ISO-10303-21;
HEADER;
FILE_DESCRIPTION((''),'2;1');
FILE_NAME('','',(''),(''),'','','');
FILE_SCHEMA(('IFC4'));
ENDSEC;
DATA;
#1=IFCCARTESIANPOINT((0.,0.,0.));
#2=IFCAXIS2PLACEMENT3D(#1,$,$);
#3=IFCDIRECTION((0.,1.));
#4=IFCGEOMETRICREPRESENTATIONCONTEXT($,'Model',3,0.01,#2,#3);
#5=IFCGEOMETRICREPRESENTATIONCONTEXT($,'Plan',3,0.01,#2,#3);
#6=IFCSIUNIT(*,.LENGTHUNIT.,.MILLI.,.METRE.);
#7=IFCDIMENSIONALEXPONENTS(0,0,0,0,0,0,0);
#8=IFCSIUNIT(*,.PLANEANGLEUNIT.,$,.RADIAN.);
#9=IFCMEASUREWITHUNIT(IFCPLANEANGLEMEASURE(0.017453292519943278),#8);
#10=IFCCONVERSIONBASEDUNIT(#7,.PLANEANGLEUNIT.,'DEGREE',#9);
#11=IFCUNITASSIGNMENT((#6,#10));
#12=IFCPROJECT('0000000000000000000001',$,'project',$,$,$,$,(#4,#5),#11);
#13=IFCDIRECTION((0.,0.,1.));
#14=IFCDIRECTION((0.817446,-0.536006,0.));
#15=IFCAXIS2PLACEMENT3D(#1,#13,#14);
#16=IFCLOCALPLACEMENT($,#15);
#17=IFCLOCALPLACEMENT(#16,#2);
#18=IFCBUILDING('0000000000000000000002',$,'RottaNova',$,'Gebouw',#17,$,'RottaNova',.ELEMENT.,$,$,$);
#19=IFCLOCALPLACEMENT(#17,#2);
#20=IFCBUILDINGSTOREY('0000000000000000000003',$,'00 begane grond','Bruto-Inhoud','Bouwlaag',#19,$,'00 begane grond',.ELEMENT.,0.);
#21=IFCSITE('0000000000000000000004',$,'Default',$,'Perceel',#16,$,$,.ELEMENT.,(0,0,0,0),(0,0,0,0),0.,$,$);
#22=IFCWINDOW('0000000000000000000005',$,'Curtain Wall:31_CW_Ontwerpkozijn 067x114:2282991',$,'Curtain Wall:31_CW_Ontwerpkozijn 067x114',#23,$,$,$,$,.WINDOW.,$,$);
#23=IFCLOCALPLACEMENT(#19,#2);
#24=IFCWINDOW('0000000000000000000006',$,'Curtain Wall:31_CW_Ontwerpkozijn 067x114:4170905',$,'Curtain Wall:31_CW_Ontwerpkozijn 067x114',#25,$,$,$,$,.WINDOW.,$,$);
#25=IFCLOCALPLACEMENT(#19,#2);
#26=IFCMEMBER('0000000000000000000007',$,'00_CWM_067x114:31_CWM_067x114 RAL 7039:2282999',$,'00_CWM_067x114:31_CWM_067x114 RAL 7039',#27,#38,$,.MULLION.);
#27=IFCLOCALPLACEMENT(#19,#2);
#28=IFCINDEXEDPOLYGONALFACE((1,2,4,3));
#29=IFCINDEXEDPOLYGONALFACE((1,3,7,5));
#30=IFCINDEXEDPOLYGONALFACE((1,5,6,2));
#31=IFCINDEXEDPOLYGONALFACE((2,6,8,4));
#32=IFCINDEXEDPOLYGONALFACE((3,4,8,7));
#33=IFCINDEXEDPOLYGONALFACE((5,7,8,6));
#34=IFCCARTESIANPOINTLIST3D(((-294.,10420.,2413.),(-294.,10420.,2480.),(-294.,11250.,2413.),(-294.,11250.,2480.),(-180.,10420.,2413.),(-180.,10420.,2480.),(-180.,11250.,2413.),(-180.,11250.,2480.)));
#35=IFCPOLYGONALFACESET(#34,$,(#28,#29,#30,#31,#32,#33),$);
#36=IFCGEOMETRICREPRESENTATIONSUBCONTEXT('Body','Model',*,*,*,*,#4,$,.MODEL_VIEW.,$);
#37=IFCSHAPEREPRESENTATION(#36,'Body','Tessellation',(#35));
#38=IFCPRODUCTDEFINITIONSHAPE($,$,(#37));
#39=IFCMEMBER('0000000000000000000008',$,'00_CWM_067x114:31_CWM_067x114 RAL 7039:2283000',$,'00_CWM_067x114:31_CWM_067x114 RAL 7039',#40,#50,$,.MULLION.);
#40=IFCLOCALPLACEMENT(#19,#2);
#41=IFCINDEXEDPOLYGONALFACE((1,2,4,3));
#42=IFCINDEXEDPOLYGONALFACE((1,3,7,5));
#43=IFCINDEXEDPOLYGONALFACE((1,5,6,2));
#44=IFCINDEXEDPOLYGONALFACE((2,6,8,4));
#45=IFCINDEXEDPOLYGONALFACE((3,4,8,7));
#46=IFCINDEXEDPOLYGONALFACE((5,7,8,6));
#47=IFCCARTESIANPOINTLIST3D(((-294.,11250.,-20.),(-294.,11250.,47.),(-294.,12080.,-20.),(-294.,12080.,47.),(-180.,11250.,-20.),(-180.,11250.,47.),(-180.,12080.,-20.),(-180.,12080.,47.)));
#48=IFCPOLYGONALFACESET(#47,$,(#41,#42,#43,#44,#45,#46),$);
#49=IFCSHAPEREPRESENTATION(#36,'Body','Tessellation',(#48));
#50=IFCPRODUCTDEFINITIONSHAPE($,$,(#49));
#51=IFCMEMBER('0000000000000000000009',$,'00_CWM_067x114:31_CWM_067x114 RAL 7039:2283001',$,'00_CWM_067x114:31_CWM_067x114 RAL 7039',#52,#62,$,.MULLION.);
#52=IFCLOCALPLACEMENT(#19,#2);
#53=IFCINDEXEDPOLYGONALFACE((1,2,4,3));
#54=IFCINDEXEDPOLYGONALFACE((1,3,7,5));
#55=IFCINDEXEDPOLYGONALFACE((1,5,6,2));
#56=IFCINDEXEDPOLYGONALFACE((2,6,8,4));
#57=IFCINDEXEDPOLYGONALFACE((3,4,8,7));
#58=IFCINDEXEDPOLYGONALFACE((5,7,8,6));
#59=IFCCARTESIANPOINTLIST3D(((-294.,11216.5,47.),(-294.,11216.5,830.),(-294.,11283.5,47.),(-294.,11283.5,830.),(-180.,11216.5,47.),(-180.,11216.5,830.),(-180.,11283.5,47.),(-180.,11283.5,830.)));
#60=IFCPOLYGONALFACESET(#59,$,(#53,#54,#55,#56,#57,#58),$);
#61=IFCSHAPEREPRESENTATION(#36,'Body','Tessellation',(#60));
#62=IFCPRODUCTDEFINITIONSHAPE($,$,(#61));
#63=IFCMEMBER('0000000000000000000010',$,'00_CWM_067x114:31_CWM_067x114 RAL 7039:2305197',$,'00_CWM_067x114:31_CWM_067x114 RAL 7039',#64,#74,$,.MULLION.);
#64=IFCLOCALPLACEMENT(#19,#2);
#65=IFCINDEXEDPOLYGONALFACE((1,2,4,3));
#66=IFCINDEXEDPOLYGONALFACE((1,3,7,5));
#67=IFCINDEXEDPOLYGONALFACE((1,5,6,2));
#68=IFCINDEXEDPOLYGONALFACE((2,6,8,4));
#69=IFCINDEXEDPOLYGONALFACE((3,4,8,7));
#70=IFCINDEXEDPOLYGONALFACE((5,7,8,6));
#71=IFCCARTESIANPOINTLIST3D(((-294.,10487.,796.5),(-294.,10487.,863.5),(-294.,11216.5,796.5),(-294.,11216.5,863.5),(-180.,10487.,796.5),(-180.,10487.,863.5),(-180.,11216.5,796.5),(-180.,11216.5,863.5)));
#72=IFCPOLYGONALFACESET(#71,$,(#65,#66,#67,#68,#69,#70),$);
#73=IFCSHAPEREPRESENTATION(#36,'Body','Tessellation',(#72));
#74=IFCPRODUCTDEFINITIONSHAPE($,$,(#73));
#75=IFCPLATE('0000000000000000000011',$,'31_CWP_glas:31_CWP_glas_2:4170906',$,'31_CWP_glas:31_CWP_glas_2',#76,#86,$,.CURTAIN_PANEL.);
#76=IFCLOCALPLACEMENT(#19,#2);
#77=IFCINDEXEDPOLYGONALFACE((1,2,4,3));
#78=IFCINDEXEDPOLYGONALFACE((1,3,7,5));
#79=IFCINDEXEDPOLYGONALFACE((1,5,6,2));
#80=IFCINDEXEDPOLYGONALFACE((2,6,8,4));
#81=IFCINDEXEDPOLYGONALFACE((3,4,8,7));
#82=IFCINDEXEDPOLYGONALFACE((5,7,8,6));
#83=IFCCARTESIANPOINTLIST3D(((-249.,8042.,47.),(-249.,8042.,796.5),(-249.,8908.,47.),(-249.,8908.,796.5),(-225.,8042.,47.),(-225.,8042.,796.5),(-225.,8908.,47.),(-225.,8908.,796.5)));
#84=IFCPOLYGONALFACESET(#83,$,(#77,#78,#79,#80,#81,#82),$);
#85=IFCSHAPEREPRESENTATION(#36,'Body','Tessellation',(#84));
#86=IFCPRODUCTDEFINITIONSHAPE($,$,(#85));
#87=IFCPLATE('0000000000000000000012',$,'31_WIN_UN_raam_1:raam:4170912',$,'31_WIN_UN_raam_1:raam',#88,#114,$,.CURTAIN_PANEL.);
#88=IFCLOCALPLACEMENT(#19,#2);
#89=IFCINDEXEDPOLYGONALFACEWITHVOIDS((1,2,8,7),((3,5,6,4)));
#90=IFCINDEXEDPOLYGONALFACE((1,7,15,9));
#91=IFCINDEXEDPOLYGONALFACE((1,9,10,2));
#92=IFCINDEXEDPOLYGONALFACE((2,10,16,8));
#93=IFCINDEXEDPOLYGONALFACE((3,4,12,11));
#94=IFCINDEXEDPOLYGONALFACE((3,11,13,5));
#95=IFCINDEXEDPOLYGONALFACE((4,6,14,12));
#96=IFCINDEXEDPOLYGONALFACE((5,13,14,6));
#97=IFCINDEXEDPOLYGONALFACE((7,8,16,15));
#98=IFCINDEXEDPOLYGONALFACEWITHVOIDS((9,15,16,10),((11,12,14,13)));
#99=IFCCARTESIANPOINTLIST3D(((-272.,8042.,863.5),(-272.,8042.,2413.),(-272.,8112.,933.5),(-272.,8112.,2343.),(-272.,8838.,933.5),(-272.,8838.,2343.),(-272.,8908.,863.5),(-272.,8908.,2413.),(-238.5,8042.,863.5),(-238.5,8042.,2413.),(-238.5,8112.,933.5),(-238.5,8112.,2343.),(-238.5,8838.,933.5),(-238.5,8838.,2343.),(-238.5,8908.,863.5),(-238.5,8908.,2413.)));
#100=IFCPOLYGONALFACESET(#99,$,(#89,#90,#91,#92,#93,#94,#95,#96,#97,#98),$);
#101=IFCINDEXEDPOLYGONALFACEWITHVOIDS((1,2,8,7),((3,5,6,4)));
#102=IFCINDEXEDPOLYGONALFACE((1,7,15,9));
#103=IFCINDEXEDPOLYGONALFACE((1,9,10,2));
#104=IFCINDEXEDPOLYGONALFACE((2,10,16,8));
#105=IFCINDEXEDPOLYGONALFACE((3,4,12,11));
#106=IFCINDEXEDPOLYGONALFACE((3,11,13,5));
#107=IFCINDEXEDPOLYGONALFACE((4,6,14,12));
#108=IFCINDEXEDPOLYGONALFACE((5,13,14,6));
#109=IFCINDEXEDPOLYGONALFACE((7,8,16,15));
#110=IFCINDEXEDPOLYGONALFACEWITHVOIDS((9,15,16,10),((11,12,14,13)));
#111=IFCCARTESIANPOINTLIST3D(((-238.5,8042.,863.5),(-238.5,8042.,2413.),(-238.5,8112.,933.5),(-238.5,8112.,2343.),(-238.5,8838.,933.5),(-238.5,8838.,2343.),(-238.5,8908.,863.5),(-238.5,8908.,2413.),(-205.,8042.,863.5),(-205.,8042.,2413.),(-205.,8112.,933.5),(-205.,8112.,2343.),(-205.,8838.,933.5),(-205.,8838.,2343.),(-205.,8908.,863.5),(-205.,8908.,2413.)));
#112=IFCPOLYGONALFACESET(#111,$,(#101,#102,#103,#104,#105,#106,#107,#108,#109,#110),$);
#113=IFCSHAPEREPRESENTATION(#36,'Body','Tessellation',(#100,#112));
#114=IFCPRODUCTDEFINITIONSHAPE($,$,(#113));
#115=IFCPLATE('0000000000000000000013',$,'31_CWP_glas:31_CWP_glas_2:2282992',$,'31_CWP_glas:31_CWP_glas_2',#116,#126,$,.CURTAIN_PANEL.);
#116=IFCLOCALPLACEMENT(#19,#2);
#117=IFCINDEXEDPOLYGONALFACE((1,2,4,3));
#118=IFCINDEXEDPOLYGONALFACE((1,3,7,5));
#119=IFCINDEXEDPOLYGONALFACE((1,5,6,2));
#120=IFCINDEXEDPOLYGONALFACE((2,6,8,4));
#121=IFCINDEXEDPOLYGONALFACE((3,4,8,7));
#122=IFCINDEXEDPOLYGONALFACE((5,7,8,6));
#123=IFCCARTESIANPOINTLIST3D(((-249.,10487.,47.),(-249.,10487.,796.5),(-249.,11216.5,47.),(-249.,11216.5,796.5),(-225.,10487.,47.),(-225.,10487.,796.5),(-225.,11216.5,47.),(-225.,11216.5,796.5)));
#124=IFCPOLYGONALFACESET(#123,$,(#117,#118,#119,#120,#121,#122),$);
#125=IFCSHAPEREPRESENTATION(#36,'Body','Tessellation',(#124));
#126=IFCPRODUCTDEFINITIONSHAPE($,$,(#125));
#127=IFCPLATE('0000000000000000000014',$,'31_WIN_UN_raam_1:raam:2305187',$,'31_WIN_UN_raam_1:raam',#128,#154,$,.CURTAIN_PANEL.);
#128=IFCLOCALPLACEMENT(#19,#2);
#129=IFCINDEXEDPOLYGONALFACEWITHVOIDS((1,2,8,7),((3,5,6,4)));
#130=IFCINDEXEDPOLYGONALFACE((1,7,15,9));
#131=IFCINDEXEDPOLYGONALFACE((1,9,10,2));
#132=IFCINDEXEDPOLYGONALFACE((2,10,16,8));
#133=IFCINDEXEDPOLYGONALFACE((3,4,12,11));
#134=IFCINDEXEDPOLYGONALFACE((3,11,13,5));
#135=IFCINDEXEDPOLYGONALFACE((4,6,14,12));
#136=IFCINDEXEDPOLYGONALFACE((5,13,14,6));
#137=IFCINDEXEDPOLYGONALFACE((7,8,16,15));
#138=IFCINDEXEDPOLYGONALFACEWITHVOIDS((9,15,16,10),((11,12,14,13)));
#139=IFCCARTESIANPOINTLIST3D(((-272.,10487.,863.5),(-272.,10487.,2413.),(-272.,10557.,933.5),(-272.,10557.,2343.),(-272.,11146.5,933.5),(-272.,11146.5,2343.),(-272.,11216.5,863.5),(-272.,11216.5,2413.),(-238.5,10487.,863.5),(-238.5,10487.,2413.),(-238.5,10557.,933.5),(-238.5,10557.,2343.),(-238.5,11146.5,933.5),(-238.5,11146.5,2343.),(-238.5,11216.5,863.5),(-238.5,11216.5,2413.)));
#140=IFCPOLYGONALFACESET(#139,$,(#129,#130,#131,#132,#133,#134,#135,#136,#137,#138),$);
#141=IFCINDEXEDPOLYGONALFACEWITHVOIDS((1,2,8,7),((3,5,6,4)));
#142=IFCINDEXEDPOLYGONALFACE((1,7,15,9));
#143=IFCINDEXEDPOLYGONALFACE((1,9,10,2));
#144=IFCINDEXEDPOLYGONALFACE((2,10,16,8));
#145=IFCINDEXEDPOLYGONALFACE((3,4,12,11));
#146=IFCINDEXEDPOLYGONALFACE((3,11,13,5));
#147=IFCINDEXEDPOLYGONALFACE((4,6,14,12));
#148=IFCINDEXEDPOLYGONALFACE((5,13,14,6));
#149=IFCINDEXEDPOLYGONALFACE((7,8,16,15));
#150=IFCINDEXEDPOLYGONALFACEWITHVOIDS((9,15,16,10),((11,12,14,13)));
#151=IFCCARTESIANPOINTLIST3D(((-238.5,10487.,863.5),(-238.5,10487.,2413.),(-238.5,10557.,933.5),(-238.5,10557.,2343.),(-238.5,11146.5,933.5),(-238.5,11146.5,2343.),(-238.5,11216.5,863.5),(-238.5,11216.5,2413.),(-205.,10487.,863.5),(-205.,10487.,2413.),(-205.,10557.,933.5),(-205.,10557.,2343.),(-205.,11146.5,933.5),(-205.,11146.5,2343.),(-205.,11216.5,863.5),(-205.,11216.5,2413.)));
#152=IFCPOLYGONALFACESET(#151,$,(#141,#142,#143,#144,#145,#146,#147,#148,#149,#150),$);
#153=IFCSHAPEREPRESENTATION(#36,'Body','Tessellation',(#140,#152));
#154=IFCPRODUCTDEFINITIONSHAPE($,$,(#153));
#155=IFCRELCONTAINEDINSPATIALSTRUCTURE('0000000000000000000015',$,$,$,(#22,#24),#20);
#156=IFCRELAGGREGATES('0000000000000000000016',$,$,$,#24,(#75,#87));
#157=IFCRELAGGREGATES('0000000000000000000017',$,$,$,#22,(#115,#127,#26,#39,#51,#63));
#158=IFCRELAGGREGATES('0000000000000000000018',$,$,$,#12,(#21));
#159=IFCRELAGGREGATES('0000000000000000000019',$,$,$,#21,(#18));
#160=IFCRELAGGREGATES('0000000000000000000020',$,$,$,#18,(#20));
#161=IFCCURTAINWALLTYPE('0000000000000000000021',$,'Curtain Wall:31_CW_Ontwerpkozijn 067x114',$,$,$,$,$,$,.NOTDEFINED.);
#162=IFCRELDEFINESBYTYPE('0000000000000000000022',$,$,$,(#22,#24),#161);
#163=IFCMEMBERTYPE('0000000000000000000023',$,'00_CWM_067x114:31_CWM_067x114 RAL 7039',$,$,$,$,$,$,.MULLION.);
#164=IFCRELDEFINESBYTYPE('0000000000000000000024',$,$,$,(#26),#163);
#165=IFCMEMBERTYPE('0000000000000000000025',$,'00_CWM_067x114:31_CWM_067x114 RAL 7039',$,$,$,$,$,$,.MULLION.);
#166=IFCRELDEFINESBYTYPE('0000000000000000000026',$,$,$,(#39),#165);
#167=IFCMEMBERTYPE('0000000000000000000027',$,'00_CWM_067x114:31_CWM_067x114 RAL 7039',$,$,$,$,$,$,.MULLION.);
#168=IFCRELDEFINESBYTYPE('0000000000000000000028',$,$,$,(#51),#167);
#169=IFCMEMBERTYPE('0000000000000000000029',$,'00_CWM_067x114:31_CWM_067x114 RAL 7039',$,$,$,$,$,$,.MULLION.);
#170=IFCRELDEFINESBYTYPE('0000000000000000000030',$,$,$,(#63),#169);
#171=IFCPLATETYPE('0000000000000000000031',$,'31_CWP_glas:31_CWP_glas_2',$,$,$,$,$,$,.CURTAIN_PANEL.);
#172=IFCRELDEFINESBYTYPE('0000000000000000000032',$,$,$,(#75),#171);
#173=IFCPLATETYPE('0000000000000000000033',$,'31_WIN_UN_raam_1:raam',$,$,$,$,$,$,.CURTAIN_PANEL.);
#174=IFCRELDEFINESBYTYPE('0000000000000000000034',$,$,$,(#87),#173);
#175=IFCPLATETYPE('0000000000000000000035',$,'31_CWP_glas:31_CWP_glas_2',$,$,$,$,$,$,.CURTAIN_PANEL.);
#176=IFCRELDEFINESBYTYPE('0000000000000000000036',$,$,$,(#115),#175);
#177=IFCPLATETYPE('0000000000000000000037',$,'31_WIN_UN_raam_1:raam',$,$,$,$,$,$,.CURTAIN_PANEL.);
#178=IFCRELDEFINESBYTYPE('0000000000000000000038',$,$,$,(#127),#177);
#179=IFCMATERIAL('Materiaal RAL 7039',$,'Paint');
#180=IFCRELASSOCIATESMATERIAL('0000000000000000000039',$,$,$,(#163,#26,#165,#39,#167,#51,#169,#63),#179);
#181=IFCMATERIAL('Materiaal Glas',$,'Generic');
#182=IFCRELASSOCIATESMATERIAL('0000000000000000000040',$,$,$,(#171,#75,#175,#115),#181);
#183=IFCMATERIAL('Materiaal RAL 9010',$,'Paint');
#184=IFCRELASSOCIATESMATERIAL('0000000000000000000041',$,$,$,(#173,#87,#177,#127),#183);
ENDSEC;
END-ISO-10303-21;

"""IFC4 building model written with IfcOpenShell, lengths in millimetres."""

from ifc_helpers import new_model, entity, si_unit, converted_unit, direction, frame, origin, place, context, subcontext, project, spatial, indexed_curve, outline, extrude, source, transform, mapped, material, type_object, type_shapes, element, aggregate, save


model = new_model("IFC4")

# Units and contexts
model_context = context("Model", 3, precision=0.01, world=origin(), true_north=direction((0.0, 1.0)))
plan_context = context("Plan", 3, precision=0.01, world=origin(), true_north=direction((0.0, 1.0)))
body_context = subcontext(model_context, "Body", "Model", "MODEL_VIEW")
ifc_project = project(units=[si_unit("LENGTHUNIT", "METRE", prefix="MILLI"), converted_unit("PLANEANGLEUNIT", "DEGREE", entity("IfcPlaneAngleMeasure", 0.017453292519943278), si_unit("PLANEANGLEUNIT", "RADIAN"), dimensions=[0, 0, 0, 0, 0, 0, 0])], contexts=[model_context, plan_context])

# Site, building, storey
site_placement = place(None, frame((0.0, 0.0, 0.0), z_axis=(0.0, 0.0, 1.0), x_axis=(0.817446, -0.536006, 0.0)))
site = spatial("IfcSite", under=ifc_project, at=site_placement, Name="Default", ObjectType="Perceel", CompositionType="ELEMENT", RefLatitude=(0, 0, 0, 0), RefLongitude=(0, 0, 0, 0), RefElevation=0.0)
building_placement = place(site_placement, origin())
building = spatial("IfcBuilding", under=site, at=building_placement, Name="RottaNova", ObjectType="Gebouw", LongName="RottaNova", CompositionType="ELEMENT")
storey_placement = place(building_placement, origin())
storey = spatial("IfcBuildingStorey", under=building, at=storey_placement, Name="00 begane grond", Description="Bruto-Inhoud", ObjectType="Bouwlaag", LongName="00 begane grond", CompositionType="ELEMENT", Elevation=0.0)

# Window
curtain_wall_type = type_object("IfcCurtainWallType", Name="Curtain Wall:31_CW_Ontwerpkozijn 067x114", PredefinedType="NOTDEFINED")
window_1_placement = place(storey_placement, origin())
window_1 = element("IfcWindow", 1, at=window_1_placement, inside=storey, type_object=curtain_wall_type, Name="Curtain Wall:31_CW_Ontwerpkozijn 067x114:2282991", ObjectType="Curtain Wall:31_CW_Ontwerpkozijn 067x114", PredefinedType="WINDOW")
ifc_material_1 = material(Name="Materiaal RAL 7039", Category="Paint")

# Window
window_2_placement = place(storey_placement, origin())
window_2 = element("IfcWindow", 2, at=window_2_placement, inside=storey, type_object=curtain_wall_type, Name="Curtain Wall:31_CW_Ontwerpkozijn 067x114:4170905", ObjectType="Curtain Wall:31_CW_Ontwerpkozijn 067x114", PredefinedType="WINDOW")

# Members
member_type_1 = type_object("IfcMemberType", Name="00_CWM_067x114:31_CWM_067x114 RAL 7039", PredefinedType="MULLION", material=ifc_material_1)
shared_shape_1 = source(origin(), body_context, "Body", "SweptSolid", [
    extrude(outline(indexed_curve([(-33.5, -57.0), (33.5, -57.0), (33.5, 57.0), (-33.5, 57.0), (-33.5, -57.0)], self_intersect=False)), frame((-33.5, -57.0, -830.0), z_axis=(0.0, 0.0, 1.0), x_axis=(-1.0, 0.0, 0.0)), (0.0, 0.0, 1.0), 830.0),
])
type_shapes(member_type_1, [shared_shape_1])
member_1_placement = place(window_1_placement, frame((-180.0, 11250.0, 2480.0), z_axis=(0.0, 1.0, 0.0), x_axis=(0.0, 0.0, 1.0)))
member_1 = element("IfcMember", 3, at=member_1_placement, type_object=member_type_1, material=ifc_material_1, Name="00_CWM_067x114:31_CWM_067x114 RAL 7039:2282999", ObjectType="00_CWM_067x114:31_CWM_067x114 RAL 7039", PredefinedType="MULLION", context=body_context, shape_type="MappedRepresentation", body=[
    mapped(shared_shape_1, transform((0.0, 0.0, 0.0), scale=1.0)),
])
member_type_2 = type_object("IfcMemberType", Name="00_CWM_067x114:31_CWM_067x114 RAL 7039", PredefinedType="MULLION", material=ifc_material_1)
shared_shape_2 = source(origin(), body_context, "Body", "SweptSolid", [
    extrude(outline(indexed_curve([(-33.5, -57.0), (33.5, -57.0), (33.5, 57.0), (-33.5, 57.0), (-33.5, -57.0)], self_intersect=False)), frame((-33.5, -57.0, -830.0), z_axis=(0.0, 0.0, 1.0), x_axis=(-1.0, 0.0, 0.0)), (0.0, 0.0, 1.0), 830.0),
])
type_shapes(member_type_2, [shared_shape_2])
member_2_placement = place(window_1_placement, frame((-180.0, 11250.0, -20.0), z_axis=(0.0, -1.0, 0.0), x_axis=(0.0, 0.0, -1.0)))
member_2 = element("IfcMember", 4, at=member_2_placement, type_object=member_type_2, material=ifc_material_1, Name="00_CWM_067x114:31_CWM_067x114 RAL 7039:2283000", ObjectType="00_CWM_067x114:31_CWM_067x114 RAL 7039", PredefinedType="MULLION", context=body_context, shape_type="MappedRepresentation", body=[
    mapped(shared_shape_2, transform((0.0, 0.0, 0.0), scale=1.0)),
])
member_type_3 = type_object("IfcMemberType", Name="00_CWM_067x114:31_CWM_067x114 RAL 7039", PredefinedType="MULLION", material=ifc_material_1)
shared_shape_3 = source(origin(), body_context, "Body", "SweptSolid", [
    extrude(outline(indexed_curve([(-33.5, -57.0), (33.5, -57.0), (33.5, 57.0), (-33.5, 57.0), (-33.5, -57.0)], self_intersect=False)), frame((0.0, -57.0, -783.0), z_axis=(0.0, 0.0, 1.0), x_axis=(-1.0, 0.0, 0.0)), (0.0, 0.0, 1.0), 783.0),
])
type_shapes(member_type_3, [shared_shape_3])
member_3_placement = place(window_1_placement, frame((-180.0, 11250.0, 47.0), z_axis=(0.0, 0.0, -1.0), x_axis=(0.0, 1.0, 0.0)))
member_3 = element("IfcMember", 5, at=member_3_placement, type_object=member_type_3, material=ifc_material_1, Name="00_CWM_067x114:31_CWM_067x114 RAL 7039:2283001", ObjectType="00_CWM_067x114:31_CWM_067x114 RAL 7039", PredefinedType="MULLION", context=body_context, shape_type="MappedRepresentation", body=[
    mapped(shared_shape_3, transform((0.0, 0.0, 0.0), scale=1.0)),
])
member_type_4 = type_object("IfcMemberType", Name="00_CWM_067x114:31_CWM_067x114 RAL 7039", PredefinedType="MULLION", material=ifc_material_1)
shared_shape_4 = source(origin(), body_context, "Body", "SweptSolid", [
    extrude(outline(indexed_curve([(-33.5, -57.0), (33.5, -57.0), (33.5, 57.0), (-33.5, 57.0), (-33.5, -57.0)], self_intersect=False)), frame((0.0, -57.0, -729.5), z_axis=(0.0, 0.0, 1.0), x_axis=(-1.0, 0.0, 0.0)), (0.0, 0.0, 1.0), 729.5),
])
type_shapes(member_type_4, [shared_shape_4])
member_4_placement = place(window_1_placement, frame((-180.0, 11216.5, 830.0), z_axis=(0.0, 1.0, 0.0), x_axis=(0.0, 0.0, 1.0)))
member_4 = element("IfcMember", 6, at=member_4_placement, type_object=member_type_4, material=ifc_material_1, Name="00_CWM_067x114:31_CWM_067x114 RAL 7039:2305197", ObjectType="00_CWM_067x114:31_CWM_067x114 RAL 7039", PredefinedType="MULLION", context=body_context, shape_type="MappedRepresentation", body=[
    mapped(shared_shape_4, transform((0.0, 0.0, 0.0), scale=1.0)),
])

# Plates
ifc_material_2 = material(Name="Materiaal Glas", Category="Generic")
plate_type_1 = type_object("IfcPlateType", Name="31_CWP_glas:31_CWP_glas_2", PredefinedType="CURTAIN_PANEL", material=ifc_material_2)
shared_shape_5 = source(origin(), body_context, "Body", "SweptSolid", [
    extrude(outline(indexed_curve([(-12.0, -433.0), (12.0, -433.0), (12.0, 433.0), (-12.0, 433.0), (-12.0, -433.0)], self_intersect=False)), frame((0.0, -57.0, 0.0), z_axis=(0.0, 0.0, 1.0), x_axis=(0.0, 1.0, 0.0)), (0.0, 0.0, 1.0), 749.5),
])
type_shapes(plate_type_1, [shared_shape_5])
plate_1_placement = place(window_2_placement, frame((-180.0, 8475.0, 47.0), z_axis=(0.0, 0.0, 1.0), x_axis=(0.0, -1.0, 0.0)))
plate_1 = element("IfcPlate", 7, at=plate_1_placement, type_object=plate_type_1, material=ifc_material_2, Name="31_CWP_glas:31_CWP_glas_2:4170906", ObjectType="31_CWP_glas:31_CWP_glas_2", PredefinedType="CURTAIN_PANEL", context=body_context, shape_type="MappedRepresentation", body=[
    mapped(shared_shape_5, transform((0.0, 0.0, 0.0), scale=1.0)),
])
ifc_material_3 = material(Name="Materiaal RAL 9010", Category="Paint")
plate_type_2 = type_object("IfcPlateType", Name="31_WIN_UN_raam_1:raam", PredefinedType="CURTAIN_PANEL", material=ifc_material_3)
shared_shape_6 = source(origin(), body_context, "Body", "SweptSolid", [
    extrude(outline(indexed_curve([(-433.0, -774.7), (433.0, -774.7), (433.0, 774.7), (-433.0, 774.7), (-433.0, -774.7)], self_intersect=False), holes=[indexed_curve([(-363.0, 704.7), (363.0, 704.7), (363.0, -704.8), (-363.0, -704.8), (-363.0, 704.7)], self_intersect=False)]), frame((0.0, -92.0, 774.8), z_axis=(0.0, 1.0, 0.0), x_axis=(1.0, 0.0, 0.0)), (0.0, 0.0, 1.0), 33.5),
    extrude(outline(indexed_curve([(-433.0, -774.7), (433.0, -774.7), (433.0, 774.7), (-433.0, 774.7), (-433.0, -774.7)], self_intersect=False), holes=[indexed_curve([(-363.0, 704.7), (363.0, 704.7), (363.0, -704.8), (-363.0, -704.8), (-363.0, 704.7)], self_intersect=False)]), frame((0.0, -58.5, 774.8), z_axis=(0.0, 1.0, 0.0), x_axis=(1.0, 0.0, 0.0)), (0.0, 0.0, 1.0), 33.5),
])
type_shapes(plate_type_2, [shared_shape_6])
plate_2_placement = place(window_2_placement, frame((-180.0, 8475.0, 863.5), z_axis=(0.0, 0.0, 1.0), x_axis=(0.0, -1.0, 0.0)))
plate_2 = element("IfcPlate", 8, at=plate_2_placement, type_object=plate_type_2, material=ifc_material_3, Name="31_WIN_UN_raam_1:raam:4170912", ObjectType="31_WIN_UN_raam_1:raam", PredefinedType="CURTAIN_PANEL", context=body_context, shape_type="MappedRepresentation", body=[
    mapped(shared_shape_6, transform((0.0, 0.0, 0.0), scale=1.0)),
])
aggregate(window_2, [plate_1, plate_2])
plate_type_3 = type_object("IfcPlateType", Name="31_CWP_glas:31_CWP_glas_2", PredefinedType="CURTAIN_PANEL", material=ifc_material_2)
shared_shape_7 = source(origin(), body_context, "Body", "SweptSolid", [
    extrude(outline(indexed_curve([(-12.0, -364.7), (12.0, -364.7), (12.0, 364.7), (-12.0, 364.7), (-12.0, -364.7)], self_intersect=False)), frame((0.0, 57.0, 0.0), z_axis=(0.0, 0.0, 1.0), x_axis=(0.0, 1.0, 0.0)), (0.0, 0.0, 1.0), 749.5),
])
type_shapes(plate_type_3, [shared_shape_7])
plate_3_placement = place(window_1_placement, frame((-180.0, 10851.7, 47.0), z_axis=(0.0, 0.0, 1.0), x_axis=(0.0, 1.0, 0.0)))
plate_3 = element("IfcPlate", 9, at=plate_3_placement, type_object=plate_type_3, material=ifc_material_2, Name="31_CWP_glas:31_CWP_glas_2:2282992", ObjectType="31_CWP_glas:31_CWP_glas_2", PredefinedType="CURTAIN_PANEL", context=body_context, shape_type="MappedRepresentation", body=[
    mapped(shared_shape_7, transform((0.0, 0.0, 0.0), scale=1.0)),
])
plate_type_4 = type_object("IfcPlateType", Name="31_WIN_UN_raam_1:raam", PredefinedType="CURTAIN_PANEL", material=ifc_material_3)
shared_shape_8 = source(origin(), body_context, "Body", "SweptSolid", [
    extrude(outline(indexed_curve([(-364.7, -774.7), (364.7, -774.7), (364.7, 774.7), (-364.7, 774.7), (-364.7, -774.7)], self_intersect=False), holes=[indexed_curve([(-294.7, 704.7), (294.7, 704.7), (294.7, -704.8), (-294.7, -704.8), (-294.7, 704.7)], self_intersect=False)]), frame((0.0, 58.5, 774.8), z_axis=(0.0, 1.0, 0.0), x_axis=(1.0, 0.0, 0.0)), (0.0, 0.0, 1.0), 33.5),
    extrude(outline(indexed_curve([(-364.7, -774.7), (364.7, -774.7), (364.7, 774.7), (-364.7, 774.7), (-364.7, -774.7)], self_intersect=False), holes=[indexed_curve([(-294.7, 704.7), (294.7, 704.7), (294.7, -704.8), (-294.7, -704.8), (-294.7, 704.7)], self_intersect=False)]), frame((0.0, 25.0, 774.8), z_axis=(0.0, 1.0, 0.0), x_axis=(1.0, 0.0, 0.0)), (0.0, 0.0, 1.0), 33.5),
])
type_shapes(plate_type_4, [shared_shape_8])
plate_4_placement = place(window_1_placement, frame((-180.0, 10851.7, 863.5), z_axis=(0.0, 0.0, 1.0), x_axis=(0.0, 1.0, 0.0)))
plate_4 = element("IfcPlate", 10, at=plate_4_placement, type_object=plate_type_4, material=ifc_material_3, Name="31_WIN_UN_raam_1:raam:2305187", ObjectType="31_WIN_UN_raam_1:raam", PredefinedType="CURTAIN_PANEL", context=body_context, shape_type="MappedRepresentation", body=[
    mapped(shared_shape_8, transform((0.0, 0.0, 0.0), scale=1.0)),
])
aggregate(window_1, [plate_3, plate_4, member_1, member_2, member_3, member_4])

save(model, "model.ifc")
